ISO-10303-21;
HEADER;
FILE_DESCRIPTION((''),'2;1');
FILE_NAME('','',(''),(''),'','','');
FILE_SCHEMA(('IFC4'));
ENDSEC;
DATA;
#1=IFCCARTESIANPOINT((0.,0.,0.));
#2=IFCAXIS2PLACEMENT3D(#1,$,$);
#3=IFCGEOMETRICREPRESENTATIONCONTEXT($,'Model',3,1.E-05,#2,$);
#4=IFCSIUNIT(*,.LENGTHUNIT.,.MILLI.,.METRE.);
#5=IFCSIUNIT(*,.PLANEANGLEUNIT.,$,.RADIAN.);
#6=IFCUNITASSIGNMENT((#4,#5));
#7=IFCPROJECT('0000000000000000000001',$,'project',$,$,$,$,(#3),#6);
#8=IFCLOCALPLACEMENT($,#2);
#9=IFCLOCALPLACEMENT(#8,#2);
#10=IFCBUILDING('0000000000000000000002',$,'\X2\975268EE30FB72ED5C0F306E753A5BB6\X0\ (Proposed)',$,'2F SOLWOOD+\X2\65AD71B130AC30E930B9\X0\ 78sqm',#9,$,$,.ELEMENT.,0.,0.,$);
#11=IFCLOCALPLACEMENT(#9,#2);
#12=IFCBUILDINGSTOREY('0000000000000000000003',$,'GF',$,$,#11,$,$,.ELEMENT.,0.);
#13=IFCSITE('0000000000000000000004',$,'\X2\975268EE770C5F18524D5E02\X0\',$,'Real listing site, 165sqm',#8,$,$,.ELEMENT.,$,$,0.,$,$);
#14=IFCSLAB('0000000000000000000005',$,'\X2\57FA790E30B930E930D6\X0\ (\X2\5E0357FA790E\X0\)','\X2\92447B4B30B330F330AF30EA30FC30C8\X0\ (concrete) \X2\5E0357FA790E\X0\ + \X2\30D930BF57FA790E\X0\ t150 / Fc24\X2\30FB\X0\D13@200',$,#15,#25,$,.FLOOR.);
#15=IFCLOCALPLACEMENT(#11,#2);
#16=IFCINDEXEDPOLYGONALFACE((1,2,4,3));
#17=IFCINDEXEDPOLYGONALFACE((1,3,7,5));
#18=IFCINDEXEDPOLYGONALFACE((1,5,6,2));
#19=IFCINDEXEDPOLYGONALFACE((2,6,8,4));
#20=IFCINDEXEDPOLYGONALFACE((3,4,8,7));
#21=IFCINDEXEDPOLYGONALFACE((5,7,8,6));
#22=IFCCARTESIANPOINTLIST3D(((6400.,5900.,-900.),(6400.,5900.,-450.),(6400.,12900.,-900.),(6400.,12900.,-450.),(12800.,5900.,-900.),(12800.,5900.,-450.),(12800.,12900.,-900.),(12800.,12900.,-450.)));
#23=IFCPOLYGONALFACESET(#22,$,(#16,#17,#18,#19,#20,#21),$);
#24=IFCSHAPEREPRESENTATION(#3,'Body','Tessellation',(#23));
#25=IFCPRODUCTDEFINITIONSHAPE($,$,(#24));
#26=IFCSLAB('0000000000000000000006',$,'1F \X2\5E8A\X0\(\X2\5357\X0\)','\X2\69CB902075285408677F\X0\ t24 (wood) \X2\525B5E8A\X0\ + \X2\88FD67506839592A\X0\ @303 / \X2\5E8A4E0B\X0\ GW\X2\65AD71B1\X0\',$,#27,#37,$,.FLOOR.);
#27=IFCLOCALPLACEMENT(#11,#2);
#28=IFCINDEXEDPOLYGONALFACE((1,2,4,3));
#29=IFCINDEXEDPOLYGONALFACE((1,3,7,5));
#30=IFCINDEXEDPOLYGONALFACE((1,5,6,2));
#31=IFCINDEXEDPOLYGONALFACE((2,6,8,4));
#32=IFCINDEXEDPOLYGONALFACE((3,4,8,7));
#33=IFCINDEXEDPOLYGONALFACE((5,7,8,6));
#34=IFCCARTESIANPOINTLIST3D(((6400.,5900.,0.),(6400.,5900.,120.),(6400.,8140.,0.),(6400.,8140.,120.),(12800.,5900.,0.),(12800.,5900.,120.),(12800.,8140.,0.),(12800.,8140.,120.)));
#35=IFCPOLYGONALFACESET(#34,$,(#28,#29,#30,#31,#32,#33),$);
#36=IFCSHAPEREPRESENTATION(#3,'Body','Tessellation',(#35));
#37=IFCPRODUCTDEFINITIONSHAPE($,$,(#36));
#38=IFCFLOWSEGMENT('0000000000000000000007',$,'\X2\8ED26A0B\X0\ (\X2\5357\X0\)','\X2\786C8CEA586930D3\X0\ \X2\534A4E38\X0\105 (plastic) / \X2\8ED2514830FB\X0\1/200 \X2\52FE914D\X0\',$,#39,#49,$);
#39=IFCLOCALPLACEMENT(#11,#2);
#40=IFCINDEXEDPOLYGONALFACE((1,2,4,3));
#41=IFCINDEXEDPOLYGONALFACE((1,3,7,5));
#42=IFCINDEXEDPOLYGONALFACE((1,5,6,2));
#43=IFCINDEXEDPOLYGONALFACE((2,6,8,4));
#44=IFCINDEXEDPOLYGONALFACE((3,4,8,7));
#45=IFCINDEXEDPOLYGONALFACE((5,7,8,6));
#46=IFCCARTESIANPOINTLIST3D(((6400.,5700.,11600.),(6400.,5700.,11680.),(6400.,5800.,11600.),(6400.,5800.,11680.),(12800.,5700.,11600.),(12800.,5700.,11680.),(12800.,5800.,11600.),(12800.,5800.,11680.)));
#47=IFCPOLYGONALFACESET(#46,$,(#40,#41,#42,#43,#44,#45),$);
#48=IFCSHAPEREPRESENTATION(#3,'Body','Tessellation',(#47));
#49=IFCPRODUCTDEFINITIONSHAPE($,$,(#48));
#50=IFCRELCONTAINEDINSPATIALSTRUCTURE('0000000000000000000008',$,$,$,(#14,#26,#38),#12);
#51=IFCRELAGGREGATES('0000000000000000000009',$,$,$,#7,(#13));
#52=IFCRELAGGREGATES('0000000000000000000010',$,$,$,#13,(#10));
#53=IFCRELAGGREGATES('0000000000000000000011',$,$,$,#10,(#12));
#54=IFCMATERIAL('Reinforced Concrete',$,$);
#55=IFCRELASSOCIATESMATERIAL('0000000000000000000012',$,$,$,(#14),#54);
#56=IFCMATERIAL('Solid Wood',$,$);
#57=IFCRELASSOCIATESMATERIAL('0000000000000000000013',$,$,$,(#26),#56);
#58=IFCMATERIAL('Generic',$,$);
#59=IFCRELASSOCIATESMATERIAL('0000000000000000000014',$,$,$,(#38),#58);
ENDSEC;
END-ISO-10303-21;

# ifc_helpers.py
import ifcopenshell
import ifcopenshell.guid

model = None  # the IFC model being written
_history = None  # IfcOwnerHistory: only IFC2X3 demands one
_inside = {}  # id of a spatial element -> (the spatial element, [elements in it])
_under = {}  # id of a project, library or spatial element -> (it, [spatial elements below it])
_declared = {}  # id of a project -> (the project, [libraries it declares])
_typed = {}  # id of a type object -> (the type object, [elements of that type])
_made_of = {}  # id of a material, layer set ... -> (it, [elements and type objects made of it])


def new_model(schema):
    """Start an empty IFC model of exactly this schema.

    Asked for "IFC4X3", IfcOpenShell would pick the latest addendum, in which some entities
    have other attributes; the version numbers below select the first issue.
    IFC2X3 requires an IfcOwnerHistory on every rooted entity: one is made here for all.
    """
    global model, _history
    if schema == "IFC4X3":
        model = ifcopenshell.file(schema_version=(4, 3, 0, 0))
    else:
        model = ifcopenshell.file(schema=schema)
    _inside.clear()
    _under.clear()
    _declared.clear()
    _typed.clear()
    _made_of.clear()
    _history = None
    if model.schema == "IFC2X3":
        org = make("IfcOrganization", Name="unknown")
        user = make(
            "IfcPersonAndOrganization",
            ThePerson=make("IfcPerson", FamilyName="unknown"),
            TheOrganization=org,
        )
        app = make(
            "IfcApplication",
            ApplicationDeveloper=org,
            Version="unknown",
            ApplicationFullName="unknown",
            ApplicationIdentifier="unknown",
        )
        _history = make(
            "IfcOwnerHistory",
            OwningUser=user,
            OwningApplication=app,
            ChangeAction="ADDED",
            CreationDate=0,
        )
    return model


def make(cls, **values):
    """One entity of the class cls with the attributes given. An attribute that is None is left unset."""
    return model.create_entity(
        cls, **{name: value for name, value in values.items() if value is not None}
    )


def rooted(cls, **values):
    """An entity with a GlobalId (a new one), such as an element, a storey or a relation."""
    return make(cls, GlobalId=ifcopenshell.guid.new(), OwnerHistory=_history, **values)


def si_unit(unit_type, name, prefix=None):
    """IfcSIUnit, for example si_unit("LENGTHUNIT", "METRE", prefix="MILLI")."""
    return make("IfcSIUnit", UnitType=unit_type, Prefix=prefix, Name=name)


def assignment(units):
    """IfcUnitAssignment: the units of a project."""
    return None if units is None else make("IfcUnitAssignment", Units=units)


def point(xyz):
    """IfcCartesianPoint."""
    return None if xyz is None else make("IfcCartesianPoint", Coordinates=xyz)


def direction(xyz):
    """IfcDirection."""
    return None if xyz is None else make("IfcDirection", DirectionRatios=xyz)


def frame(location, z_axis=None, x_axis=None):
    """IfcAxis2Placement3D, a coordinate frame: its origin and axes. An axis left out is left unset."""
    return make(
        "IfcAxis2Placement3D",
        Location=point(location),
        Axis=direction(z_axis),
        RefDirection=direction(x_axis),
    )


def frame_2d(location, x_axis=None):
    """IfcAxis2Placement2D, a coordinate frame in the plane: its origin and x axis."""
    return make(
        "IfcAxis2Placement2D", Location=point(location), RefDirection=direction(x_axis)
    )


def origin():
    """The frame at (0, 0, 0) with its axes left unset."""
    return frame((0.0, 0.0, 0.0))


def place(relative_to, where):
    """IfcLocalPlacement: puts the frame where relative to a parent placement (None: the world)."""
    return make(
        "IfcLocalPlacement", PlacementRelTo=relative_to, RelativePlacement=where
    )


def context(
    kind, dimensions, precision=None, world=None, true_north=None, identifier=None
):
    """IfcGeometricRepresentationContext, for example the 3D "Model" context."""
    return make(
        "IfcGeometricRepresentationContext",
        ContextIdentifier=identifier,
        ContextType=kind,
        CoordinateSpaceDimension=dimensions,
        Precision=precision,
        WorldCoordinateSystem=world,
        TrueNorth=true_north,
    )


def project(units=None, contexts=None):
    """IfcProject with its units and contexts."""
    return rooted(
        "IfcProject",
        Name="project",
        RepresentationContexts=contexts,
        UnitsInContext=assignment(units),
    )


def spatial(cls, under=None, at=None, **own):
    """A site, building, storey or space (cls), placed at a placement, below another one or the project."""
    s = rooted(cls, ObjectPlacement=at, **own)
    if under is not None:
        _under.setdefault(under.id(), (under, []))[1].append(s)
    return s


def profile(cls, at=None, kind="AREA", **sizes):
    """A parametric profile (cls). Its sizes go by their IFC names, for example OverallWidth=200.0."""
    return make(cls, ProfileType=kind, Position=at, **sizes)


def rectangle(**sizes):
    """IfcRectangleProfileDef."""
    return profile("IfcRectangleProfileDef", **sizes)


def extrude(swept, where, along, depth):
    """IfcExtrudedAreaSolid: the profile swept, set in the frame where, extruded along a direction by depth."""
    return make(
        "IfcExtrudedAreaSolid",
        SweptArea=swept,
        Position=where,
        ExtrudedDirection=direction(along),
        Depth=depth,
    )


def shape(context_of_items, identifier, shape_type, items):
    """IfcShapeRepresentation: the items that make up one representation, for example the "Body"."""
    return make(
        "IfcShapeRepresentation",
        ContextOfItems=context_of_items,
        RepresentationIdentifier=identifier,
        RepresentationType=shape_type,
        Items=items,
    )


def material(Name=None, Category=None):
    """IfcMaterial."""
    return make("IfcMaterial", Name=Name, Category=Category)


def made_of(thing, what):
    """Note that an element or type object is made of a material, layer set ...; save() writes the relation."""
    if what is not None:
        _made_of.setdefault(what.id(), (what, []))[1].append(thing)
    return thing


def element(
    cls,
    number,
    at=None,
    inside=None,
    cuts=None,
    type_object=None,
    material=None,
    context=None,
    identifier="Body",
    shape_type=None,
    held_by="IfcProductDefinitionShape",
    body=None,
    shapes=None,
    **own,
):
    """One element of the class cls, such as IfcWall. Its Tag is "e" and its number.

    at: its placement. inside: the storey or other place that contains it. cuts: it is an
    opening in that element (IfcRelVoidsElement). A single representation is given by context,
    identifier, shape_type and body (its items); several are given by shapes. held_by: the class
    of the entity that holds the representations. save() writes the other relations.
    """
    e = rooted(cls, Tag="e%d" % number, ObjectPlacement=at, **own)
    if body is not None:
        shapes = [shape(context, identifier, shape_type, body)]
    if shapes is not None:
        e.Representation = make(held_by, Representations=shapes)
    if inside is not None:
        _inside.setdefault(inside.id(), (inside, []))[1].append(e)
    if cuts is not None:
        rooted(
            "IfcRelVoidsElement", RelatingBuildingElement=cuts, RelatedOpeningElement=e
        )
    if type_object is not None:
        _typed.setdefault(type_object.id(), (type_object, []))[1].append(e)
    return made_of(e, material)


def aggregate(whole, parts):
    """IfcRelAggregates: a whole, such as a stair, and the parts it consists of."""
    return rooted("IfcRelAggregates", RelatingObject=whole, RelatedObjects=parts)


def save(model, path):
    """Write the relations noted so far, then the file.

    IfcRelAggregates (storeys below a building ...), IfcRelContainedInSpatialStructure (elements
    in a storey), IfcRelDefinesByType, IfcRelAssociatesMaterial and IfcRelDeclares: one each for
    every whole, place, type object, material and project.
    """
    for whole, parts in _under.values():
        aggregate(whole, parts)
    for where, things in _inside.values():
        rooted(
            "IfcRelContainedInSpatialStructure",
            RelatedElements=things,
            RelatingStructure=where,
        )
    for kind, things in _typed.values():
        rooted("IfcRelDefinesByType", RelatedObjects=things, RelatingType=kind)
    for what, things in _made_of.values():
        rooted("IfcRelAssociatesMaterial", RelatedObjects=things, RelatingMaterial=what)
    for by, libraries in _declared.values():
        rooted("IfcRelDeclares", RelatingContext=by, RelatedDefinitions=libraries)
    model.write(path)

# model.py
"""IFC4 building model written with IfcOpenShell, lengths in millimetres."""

from ifc_helpers import new_model, si_unit, frame, frame_2d, origin, place, context, project, spatial, rectangle, extrude, material, element, save


model = new_model("IFC4")

# Units and contexts
model_context = context("Model", 3, precision=1e-05, world=origin())
ifc_project = project(units=[si_unit("LENGTHUNIT", "METRE", prefix="MILLI"), si_unit("PLANEANGLEUNIT", "RADIAN")], contexts=[model_context])

# Site, building, storey
site_placement = place(None, origin())
site = spatial("IfcSite", under=ifc_project, at=site_placement, Name="青森県弘前市", ObjectType="Real listing site, 165sqm", CompositionType="ELEMENT", RefElevation=0.0)
building_placement = place(site_placement, origin())
building = spatial("IfcBuilding", under=site, at=building_placement, Name="青森・狭小の町家 (Proposed)", ObjectType="2F SOLWOOD+断熱ガラス 78sqm", CompositionType="ELEMENT", ElevationOfRefHeight=0.0, ElevationOfTerrain=0.0)
storey_placement = place(building_placement, origin())
storey = spatial("IfcBuildingStorey", under=building, at=storey_placement, Name="GF", CompositionType="ELEMENT", Elevation=0.0)

# Shared definitions
ifc_material_1 = material(Name="Solid Wood")

# Slabs
ifc_material_2 = material(Name="Reinforced Concrete")
slab_1_placement = place(storey_placement, frame((3200.0, 2950.0, -450.0)))
element("IfcSlab", 1, at=slab_1_placement, inside=storey, material=ifc_material_2, Name="基礎スラブ (布基礎)", Description="鉄筋コンクリート (concrete) 布基礎 + ベタ基礎 t150 / Fc24・D13@200", PredefinedType="FLOOR", context=model_context, shape_type="SweptSolid", body=[
    extrude(rectangle(XDim=6400.0, YDim=7000.0, at=frame_2d((3200.0, 3500.0))), frame((3200.0, 2950.0, -450.0)), (0.0, 0.0, 1.0), 450.0),
])
slab_2_placement = place(storey_placement, frame((3200.0, 2950.0, 0.0)))
element("IfcSlab", 2, at=slab_2_placement, inside=storey, material=ifc_material_1, Name="1F 床(南)", Description="構造用合板 t24 (wood) 剛床 + 製材根太 @303 / 床下 GW断熱", PredefinedType="FLOOR", context=model_context, shape_type="SweptSolid", body=[
    extrude(rectangle(XDim=6400.0, YDim=2240.0, at=frame_2d((3200.0, 1120.0))), frame((3200.0, 2950.0, 0.0)), (0.0, 0.0, 1.0), 120.0),
])

# Shared definitions
ifc_material_3 = material(Name="Generic")

# Flow segment
flow_segment_1_placement = place(storey_placement, frame((3200.0, 2850.0, 5800.0)))
element("IfcFlowSegment", 3, at=flow_segment_1_placement, inside=storey, material=ifc_material_3, Name="軒樋 (南)", Description="硬質塩ビ 半丸105 (plastic) / 軒先・1/200 勾配", context=model_context, shape_type="SweptSolid", body=[
    extrude(rectangle(XDim=6400.0, YDim=100.0, at=frame_2d((3200.0, 50.0))), frame((3200.0, 2850.0, 5800.0)), (0.0, 0.0, 1.0), 80.0),
])

save(model, "model.ifc")
